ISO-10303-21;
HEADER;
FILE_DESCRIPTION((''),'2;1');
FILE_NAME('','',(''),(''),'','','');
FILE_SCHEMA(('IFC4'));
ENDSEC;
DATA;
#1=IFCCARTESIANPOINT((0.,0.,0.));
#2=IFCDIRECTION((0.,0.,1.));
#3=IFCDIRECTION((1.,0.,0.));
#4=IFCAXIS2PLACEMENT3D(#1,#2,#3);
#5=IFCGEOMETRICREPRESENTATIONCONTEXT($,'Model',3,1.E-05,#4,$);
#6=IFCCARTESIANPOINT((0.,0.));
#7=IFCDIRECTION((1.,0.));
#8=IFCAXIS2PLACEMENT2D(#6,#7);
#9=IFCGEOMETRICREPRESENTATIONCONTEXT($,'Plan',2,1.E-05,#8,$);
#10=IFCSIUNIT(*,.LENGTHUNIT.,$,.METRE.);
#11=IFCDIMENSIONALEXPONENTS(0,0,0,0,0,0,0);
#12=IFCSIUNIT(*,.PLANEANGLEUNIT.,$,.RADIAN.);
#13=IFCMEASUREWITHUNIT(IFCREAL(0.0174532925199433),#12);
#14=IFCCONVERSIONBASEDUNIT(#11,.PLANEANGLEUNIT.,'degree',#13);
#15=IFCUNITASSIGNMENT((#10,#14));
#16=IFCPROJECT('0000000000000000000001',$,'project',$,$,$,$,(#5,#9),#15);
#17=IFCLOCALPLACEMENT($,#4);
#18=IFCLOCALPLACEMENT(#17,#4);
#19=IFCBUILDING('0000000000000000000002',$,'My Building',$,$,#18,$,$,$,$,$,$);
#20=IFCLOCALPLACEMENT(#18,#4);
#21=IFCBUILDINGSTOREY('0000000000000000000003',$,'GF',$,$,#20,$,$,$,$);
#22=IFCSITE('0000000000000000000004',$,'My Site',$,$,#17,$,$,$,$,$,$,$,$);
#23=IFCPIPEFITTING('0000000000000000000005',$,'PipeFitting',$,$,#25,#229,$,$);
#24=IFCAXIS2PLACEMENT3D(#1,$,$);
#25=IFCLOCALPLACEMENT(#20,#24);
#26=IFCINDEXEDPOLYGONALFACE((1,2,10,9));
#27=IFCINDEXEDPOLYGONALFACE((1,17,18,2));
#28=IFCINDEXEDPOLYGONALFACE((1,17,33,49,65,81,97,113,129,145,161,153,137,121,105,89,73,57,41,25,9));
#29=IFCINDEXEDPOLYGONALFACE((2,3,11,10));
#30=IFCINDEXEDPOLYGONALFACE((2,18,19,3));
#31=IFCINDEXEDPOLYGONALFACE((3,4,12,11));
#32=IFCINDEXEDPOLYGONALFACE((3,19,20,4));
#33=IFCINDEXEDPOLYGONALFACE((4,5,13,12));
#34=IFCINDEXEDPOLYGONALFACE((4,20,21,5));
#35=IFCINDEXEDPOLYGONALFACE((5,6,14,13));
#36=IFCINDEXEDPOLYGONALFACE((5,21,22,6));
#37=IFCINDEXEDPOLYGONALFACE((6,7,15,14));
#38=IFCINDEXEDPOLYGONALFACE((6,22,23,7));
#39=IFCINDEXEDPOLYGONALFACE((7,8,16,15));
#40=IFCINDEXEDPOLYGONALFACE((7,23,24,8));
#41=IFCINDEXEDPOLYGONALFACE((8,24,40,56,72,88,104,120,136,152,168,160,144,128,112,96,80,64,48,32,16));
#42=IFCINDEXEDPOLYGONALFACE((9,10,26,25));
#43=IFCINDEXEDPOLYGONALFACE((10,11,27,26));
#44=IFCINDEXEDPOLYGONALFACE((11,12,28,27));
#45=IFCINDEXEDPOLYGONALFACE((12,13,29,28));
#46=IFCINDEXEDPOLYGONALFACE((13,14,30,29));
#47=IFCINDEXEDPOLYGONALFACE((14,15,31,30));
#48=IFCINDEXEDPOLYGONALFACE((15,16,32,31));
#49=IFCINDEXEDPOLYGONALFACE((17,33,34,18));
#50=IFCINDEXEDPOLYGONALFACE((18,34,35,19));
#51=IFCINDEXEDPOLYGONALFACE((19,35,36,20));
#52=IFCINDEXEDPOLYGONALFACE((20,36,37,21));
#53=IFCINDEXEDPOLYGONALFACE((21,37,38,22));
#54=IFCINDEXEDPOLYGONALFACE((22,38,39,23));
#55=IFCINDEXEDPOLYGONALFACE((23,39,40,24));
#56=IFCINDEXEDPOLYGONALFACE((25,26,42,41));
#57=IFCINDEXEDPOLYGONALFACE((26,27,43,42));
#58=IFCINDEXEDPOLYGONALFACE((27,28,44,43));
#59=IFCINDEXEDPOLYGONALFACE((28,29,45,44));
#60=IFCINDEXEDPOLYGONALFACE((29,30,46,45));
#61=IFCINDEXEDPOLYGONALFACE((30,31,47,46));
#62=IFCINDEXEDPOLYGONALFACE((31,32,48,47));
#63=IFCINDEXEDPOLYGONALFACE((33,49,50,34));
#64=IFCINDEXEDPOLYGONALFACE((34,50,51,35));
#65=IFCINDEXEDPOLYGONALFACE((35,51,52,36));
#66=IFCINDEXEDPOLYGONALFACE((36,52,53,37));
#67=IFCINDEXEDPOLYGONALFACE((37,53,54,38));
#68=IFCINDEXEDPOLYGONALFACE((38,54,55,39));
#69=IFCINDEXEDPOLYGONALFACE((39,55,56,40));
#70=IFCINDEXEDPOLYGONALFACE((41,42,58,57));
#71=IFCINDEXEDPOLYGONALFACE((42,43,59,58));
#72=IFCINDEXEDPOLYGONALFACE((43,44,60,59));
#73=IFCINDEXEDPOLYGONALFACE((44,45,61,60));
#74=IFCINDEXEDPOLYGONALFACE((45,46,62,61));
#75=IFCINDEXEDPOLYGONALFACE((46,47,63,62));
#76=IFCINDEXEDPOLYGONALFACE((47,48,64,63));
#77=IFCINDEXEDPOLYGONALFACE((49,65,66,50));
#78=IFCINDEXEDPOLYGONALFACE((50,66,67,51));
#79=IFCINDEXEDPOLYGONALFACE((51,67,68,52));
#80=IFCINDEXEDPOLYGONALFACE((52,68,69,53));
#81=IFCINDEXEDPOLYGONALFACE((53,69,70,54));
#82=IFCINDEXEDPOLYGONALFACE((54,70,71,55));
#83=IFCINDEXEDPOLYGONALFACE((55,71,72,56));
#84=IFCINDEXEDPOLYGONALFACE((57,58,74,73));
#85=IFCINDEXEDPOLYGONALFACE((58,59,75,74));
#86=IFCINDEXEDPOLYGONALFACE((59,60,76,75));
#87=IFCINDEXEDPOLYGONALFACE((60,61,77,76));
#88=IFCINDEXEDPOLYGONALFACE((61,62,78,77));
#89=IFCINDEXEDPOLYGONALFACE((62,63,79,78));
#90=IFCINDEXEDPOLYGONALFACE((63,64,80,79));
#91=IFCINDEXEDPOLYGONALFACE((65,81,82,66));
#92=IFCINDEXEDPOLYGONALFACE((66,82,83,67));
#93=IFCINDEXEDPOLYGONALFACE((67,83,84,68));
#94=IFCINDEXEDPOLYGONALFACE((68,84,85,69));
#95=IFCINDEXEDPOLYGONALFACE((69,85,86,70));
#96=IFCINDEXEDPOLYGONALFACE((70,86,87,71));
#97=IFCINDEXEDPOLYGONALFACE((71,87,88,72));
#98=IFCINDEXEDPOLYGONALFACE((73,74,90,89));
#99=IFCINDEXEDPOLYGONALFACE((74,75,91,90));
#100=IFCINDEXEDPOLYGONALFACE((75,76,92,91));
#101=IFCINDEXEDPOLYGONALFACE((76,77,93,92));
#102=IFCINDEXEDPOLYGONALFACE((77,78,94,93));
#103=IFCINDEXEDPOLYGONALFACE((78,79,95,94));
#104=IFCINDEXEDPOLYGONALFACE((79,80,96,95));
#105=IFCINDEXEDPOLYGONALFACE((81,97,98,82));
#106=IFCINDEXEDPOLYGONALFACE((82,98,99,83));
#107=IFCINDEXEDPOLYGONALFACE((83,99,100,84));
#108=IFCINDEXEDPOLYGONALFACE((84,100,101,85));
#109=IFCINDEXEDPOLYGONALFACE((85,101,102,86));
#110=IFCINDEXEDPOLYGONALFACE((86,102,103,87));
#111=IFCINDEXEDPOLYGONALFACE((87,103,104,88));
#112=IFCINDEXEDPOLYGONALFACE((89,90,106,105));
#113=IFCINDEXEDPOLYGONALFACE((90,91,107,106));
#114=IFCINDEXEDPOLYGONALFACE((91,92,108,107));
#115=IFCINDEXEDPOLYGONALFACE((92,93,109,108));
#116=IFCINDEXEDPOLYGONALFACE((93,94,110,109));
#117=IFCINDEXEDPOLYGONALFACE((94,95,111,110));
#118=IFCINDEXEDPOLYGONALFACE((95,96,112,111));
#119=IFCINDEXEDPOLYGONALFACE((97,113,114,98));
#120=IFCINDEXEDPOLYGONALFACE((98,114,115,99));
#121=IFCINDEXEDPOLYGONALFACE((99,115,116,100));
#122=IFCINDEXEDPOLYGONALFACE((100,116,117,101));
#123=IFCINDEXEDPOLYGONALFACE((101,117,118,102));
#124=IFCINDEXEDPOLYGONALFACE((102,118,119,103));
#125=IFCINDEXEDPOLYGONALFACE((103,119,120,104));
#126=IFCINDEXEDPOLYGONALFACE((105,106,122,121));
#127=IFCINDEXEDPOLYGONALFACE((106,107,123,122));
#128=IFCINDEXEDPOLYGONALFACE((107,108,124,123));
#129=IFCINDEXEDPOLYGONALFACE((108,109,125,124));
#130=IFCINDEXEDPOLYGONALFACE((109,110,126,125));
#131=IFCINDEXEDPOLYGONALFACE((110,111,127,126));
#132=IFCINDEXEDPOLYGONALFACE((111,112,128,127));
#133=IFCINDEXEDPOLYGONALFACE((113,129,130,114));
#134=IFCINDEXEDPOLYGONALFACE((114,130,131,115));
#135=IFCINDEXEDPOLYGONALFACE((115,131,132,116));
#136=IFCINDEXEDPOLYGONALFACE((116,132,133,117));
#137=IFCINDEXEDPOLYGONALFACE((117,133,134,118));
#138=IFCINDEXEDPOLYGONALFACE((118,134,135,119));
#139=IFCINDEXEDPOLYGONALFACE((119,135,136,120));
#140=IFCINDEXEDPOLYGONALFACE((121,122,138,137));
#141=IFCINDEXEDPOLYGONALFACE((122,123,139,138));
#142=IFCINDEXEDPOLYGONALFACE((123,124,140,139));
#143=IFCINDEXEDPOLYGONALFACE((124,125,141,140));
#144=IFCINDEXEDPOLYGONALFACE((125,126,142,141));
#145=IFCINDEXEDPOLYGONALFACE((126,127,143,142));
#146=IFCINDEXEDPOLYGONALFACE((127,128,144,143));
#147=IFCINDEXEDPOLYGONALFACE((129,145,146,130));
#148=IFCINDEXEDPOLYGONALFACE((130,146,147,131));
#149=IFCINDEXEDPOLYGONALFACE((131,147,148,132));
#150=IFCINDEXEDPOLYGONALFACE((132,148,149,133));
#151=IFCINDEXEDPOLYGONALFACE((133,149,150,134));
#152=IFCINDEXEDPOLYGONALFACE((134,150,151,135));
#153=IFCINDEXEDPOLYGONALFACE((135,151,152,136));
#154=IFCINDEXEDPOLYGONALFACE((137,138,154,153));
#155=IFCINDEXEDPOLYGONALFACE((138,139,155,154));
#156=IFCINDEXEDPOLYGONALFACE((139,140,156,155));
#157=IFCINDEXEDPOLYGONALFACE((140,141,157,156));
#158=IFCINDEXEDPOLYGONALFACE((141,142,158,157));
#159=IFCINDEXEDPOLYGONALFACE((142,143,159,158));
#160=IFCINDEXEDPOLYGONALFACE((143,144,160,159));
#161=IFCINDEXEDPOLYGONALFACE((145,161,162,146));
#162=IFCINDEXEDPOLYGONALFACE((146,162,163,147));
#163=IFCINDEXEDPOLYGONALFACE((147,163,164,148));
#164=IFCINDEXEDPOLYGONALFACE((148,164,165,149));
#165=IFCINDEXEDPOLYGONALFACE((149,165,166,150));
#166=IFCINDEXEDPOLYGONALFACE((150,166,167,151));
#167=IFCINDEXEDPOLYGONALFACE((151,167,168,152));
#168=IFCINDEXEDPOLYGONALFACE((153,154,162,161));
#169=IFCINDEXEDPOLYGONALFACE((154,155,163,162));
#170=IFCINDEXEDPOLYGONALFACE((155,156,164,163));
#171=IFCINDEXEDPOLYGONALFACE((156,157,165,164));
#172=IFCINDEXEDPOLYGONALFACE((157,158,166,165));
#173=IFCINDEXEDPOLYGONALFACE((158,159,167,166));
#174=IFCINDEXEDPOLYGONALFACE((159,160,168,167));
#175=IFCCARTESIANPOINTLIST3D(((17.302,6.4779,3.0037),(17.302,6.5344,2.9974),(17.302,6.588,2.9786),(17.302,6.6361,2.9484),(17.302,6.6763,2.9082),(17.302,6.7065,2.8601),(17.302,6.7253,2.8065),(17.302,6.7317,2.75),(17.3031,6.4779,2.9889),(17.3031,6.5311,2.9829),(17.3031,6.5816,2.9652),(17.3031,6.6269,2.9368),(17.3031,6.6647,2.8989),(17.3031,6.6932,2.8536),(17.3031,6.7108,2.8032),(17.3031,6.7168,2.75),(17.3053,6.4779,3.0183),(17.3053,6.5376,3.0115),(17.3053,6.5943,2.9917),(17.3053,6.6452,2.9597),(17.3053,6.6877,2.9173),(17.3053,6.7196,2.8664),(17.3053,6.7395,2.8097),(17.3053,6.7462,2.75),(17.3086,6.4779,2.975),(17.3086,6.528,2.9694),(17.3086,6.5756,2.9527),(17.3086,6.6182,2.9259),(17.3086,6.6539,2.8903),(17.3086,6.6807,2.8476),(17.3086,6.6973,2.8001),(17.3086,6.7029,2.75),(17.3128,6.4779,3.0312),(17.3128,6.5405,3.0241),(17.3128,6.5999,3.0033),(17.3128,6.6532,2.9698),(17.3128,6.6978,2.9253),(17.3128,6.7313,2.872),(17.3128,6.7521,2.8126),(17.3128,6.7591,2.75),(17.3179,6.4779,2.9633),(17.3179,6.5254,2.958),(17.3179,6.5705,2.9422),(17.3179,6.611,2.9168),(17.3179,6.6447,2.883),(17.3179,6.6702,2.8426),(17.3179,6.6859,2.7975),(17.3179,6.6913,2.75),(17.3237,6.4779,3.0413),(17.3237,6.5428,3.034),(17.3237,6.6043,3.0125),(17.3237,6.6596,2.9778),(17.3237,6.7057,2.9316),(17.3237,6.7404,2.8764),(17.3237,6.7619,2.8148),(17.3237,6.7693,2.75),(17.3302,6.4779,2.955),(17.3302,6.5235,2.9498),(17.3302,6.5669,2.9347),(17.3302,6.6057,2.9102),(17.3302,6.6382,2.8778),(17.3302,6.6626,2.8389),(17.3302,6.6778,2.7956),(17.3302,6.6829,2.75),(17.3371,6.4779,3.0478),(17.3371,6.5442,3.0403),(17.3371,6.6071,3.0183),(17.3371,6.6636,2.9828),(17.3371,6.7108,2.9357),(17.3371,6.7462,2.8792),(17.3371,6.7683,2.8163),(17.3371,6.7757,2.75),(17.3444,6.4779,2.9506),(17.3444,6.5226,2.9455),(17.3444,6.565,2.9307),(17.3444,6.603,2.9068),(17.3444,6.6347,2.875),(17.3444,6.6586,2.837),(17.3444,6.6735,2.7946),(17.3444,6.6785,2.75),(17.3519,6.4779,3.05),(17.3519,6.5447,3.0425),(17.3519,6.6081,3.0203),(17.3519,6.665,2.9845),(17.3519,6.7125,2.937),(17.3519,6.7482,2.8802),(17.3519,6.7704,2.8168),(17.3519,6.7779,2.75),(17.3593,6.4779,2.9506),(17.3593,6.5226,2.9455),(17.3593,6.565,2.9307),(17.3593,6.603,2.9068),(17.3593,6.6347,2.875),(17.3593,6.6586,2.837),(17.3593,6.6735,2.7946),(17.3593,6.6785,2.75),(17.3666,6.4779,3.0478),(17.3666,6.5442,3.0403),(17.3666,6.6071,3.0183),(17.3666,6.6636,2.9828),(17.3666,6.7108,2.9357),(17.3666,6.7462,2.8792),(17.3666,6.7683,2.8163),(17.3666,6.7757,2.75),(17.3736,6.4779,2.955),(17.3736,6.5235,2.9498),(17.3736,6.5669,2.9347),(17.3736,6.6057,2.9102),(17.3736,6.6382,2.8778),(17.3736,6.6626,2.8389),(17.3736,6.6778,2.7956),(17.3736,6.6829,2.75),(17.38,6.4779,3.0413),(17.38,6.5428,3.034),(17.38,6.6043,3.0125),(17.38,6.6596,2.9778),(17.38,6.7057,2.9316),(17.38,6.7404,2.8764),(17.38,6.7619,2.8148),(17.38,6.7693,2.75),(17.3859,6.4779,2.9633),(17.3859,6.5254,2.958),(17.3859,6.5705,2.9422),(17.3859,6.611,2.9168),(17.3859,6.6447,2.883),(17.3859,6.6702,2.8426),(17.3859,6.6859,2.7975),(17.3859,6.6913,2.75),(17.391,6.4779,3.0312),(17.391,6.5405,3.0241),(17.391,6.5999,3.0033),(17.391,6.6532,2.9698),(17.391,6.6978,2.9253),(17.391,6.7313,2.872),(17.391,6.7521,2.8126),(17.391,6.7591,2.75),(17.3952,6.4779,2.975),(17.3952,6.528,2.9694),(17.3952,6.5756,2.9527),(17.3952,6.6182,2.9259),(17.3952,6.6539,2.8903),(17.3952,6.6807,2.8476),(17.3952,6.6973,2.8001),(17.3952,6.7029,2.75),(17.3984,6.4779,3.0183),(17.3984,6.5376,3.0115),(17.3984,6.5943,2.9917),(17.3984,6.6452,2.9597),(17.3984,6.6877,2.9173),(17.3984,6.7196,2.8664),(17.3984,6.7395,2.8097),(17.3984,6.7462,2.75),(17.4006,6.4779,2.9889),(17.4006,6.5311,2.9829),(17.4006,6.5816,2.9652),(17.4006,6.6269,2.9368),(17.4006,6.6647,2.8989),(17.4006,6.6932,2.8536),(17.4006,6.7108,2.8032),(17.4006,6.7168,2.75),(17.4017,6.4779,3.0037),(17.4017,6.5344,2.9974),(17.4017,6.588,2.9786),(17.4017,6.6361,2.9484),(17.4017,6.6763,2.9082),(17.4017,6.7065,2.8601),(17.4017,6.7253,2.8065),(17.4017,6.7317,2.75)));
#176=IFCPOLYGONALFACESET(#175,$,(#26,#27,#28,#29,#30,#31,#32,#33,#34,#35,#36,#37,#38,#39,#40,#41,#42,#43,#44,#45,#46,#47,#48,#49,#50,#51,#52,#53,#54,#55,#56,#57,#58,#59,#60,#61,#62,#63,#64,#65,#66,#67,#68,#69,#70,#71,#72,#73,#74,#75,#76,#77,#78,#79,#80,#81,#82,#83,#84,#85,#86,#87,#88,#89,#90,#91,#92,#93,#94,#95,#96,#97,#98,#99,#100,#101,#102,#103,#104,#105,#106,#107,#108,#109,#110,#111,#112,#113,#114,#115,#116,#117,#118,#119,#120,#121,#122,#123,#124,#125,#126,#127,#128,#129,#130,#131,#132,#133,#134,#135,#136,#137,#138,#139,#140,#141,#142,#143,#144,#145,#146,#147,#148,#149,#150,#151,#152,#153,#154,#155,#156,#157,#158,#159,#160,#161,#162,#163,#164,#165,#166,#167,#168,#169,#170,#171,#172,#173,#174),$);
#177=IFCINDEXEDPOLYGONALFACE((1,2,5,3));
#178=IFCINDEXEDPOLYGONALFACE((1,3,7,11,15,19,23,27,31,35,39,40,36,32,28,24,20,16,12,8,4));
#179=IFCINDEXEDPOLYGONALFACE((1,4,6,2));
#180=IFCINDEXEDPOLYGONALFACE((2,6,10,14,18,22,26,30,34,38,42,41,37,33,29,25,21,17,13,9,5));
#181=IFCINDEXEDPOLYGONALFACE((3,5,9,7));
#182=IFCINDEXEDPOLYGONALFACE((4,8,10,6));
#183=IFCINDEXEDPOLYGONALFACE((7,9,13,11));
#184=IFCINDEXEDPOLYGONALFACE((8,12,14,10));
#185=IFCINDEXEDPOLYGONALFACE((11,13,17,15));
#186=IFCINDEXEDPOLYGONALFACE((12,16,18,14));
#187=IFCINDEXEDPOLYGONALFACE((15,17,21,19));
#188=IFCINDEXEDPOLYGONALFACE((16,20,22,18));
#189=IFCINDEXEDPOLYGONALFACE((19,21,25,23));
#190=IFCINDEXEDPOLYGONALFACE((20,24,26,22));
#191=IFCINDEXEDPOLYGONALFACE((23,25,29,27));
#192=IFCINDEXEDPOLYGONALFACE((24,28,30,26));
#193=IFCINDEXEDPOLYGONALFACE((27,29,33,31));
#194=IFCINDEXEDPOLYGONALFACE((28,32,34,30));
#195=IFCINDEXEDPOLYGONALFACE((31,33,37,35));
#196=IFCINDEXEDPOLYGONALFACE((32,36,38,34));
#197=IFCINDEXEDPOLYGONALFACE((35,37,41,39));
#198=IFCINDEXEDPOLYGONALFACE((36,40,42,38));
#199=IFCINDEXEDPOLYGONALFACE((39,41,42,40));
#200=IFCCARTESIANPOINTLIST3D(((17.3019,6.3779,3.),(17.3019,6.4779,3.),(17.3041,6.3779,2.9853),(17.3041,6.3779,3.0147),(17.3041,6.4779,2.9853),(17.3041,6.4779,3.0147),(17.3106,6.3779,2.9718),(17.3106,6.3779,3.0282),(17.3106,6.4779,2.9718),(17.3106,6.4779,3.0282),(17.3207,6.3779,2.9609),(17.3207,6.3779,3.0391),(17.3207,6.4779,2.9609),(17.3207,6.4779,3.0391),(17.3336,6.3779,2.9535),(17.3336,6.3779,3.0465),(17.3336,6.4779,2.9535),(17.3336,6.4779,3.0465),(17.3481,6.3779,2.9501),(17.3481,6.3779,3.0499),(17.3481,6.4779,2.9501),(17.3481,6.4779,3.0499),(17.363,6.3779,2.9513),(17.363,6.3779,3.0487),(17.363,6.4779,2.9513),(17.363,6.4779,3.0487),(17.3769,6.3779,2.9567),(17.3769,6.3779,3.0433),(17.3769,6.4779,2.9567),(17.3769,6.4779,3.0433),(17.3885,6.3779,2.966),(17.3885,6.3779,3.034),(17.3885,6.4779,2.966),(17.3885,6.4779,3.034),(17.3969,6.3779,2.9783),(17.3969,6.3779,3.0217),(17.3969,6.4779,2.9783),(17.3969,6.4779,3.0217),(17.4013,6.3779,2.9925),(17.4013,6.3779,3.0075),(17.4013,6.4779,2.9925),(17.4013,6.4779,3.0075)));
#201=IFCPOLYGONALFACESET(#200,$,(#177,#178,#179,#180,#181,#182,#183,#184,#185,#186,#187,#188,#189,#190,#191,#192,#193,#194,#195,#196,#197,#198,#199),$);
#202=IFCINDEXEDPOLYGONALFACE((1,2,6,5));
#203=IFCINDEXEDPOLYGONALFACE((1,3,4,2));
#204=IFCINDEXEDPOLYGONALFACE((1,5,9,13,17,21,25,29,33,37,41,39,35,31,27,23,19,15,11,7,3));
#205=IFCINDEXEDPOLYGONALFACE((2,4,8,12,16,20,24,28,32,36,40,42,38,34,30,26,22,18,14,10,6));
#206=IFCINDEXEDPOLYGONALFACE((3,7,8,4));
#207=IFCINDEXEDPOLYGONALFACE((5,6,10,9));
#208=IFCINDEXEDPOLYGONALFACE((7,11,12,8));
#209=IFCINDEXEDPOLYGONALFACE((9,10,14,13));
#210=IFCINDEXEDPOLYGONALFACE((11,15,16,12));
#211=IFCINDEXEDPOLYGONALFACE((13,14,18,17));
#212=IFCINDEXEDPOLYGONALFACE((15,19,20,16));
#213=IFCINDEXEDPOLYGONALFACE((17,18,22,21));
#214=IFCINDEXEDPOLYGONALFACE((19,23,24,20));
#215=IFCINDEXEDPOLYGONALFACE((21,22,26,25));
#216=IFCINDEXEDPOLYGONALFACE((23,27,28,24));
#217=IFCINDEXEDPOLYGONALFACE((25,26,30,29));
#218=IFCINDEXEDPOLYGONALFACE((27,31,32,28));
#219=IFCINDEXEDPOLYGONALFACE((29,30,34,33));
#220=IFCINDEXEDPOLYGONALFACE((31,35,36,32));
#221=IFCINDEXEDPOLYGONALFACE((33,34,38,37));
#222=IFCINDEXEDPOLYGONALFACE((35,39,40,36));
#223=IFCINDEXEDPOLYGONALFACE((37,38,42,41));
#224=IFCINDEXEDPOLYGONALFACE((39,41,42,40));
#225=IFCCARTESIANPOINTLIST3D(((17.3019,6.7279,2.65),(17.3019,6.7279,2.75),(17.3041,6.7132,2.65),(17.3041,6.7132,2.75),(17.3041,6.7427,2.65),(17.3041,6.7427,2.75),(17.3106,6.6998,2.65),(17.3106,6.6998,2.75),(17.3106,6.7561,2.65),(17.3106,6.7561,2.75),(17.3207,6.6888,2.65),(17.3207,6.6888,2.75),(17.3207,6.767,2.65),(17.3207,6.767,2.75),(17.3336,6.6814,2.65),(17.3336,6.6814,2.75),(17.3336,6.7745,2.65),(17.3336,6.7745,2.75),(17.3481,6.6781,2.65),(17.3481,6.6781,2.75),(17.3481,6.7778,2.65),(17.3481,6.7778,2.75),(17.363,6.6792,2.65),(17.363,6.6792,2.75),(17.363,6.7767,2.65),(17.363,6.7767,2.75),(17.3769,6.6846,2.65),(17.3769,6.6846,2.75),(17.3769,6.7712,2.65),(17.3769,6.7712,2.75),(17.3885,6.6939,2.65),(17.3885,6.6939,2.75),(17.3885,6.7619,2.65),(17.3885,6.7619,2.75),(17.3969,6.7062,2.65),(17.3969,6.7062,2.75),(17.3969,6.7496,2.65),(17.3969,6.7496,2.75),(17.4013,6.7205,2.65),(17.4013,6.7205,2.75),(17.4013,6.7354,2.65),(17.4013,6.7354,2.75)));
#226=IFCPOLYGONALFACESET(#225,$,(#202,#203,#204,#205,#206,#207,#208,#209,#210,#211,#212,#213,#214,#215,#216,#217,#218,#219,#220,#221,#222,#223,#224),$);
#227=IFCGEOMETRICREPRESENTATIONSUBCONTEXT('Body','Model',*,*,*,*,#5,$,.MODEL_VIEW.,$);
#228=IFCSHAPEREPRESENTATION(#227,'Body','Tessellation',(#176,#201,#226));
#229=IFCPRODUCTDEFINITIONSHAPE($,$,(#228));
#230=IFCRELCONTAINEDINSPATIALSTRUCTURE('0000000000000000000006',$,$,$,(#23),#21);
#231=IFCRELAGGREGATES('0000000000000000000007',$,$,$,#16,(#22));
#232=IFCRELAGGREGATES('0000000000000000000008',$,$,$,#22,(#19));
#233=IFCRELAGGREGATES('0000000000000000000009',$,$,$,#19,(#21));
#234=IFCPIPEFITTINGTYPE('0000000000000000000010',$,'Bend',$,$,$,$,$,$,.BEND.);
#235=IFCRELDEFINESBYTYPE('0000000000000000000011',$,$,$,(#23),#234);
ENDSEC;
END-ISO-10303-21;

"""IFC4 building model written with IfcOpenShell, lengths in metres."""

from ifc_helpers import new_model, entity, si_unit, converted_unit, frame, origin_with_axes, origin_2d_with_axis, place, context, subcontext, project, spatial, circle, extrude, source, transform, mapped, type_object, type_shapes, element, save


model = new_model("IFC4")

# Units and contexts
model_context = context("Model", 3, precision=1e-05, world=origin_with_axes())
plan_context = context("Plan", 2, precision=1e-05, world=origin_2d_with_axis())
body_context_1 = subcontext(model_context, "Body", "Model", "MODEL_VIEW")
ifc_project = project(units=[si_unit("LENGTHUNIT", "METRE"), converted_unit("PLANEANGLEUNIT", "degree", entity("IfcReal", 0.0174532925199433), si_unit("PLANEANGLEUNIT", "RADIAN"), dimensions=[0, 0, 0, 0, 0, 0, 0])], contexts=[model_context, plan_context])

# Site, building, storey
site_placement = place(None, origin_with_axes())
site = spatial("IfcSite", under=ifc_project, at=site_placement, Name="My Site")
building_placement = place(site_placement, origin_with_axes())
building = spatial("IfcBuilding", under=site, at=building_placement, Name="My Building")
storey_placement = place(building_placement, origin_with_axes())
storey = spatial("IfcBuildingStorey", under=building, at=storey_placement, Name="GF")

# Pipe fitting
pipe_fitting_type = type_object("IfcPipeFittingType", Name="Bend", PredefinedType="BEND")
shared_shape_1 = source(origin_with_axes(), body_context_1, "Body", "SolidModel", [
    entity("IfcSweptDiskSolid", entity("IfcIndexedPolyCurve", entity("IfcCartesianPointList3D", [[0.0, 0.0, 0.1], [0.0, -0.0732, 0.2768], [0.0, -0.25, 0.35]]), [entity("IfcArcIndex", [1, 2, 3])]), 0.05),
    extrude(circle(Radius=0.05), origin_with_axes(), (0.0, 0.0, 1.0), 0.1),
    extrude(circle(Radius=0.05), frame((0.0, -0.25, 0.35), z_axis=(0.0, -1.0, 0.0), x_axis=(1.0, 0.0, 0.0)), (0.0, 0.0, 1.0), 0.1),
])
type_shapes(pipe_fitting_type, [shared_shape_1])
for number, where, z_axis, x_axis, name in (
    (1, (17.3519, 6.3779, 3.0), (0.0, 1.0, 0.0), (-1.0, 0.0, 0.0), "PipeFitting"),
):
    element("IfcPipeFitting", number, at=place(storey_placement, frame(where, z_axis=z_axis, x_axis=x_axis)), inside=storey, type_object=pipe_fitting_type, Name=name, context=body_context_1, shape_type="MappedRepresentation", body=[
        mapped(shared_shape_1, transform((0.0, 0.0, 0.0), x_axis=(1.0, 0.0, 0.0), y_axis=(0.0, 1.0, 0.0), z_axis=(0.0, 0.0, 1.0), scale=1.0)),
    ])

save(model, "model.ifc")
